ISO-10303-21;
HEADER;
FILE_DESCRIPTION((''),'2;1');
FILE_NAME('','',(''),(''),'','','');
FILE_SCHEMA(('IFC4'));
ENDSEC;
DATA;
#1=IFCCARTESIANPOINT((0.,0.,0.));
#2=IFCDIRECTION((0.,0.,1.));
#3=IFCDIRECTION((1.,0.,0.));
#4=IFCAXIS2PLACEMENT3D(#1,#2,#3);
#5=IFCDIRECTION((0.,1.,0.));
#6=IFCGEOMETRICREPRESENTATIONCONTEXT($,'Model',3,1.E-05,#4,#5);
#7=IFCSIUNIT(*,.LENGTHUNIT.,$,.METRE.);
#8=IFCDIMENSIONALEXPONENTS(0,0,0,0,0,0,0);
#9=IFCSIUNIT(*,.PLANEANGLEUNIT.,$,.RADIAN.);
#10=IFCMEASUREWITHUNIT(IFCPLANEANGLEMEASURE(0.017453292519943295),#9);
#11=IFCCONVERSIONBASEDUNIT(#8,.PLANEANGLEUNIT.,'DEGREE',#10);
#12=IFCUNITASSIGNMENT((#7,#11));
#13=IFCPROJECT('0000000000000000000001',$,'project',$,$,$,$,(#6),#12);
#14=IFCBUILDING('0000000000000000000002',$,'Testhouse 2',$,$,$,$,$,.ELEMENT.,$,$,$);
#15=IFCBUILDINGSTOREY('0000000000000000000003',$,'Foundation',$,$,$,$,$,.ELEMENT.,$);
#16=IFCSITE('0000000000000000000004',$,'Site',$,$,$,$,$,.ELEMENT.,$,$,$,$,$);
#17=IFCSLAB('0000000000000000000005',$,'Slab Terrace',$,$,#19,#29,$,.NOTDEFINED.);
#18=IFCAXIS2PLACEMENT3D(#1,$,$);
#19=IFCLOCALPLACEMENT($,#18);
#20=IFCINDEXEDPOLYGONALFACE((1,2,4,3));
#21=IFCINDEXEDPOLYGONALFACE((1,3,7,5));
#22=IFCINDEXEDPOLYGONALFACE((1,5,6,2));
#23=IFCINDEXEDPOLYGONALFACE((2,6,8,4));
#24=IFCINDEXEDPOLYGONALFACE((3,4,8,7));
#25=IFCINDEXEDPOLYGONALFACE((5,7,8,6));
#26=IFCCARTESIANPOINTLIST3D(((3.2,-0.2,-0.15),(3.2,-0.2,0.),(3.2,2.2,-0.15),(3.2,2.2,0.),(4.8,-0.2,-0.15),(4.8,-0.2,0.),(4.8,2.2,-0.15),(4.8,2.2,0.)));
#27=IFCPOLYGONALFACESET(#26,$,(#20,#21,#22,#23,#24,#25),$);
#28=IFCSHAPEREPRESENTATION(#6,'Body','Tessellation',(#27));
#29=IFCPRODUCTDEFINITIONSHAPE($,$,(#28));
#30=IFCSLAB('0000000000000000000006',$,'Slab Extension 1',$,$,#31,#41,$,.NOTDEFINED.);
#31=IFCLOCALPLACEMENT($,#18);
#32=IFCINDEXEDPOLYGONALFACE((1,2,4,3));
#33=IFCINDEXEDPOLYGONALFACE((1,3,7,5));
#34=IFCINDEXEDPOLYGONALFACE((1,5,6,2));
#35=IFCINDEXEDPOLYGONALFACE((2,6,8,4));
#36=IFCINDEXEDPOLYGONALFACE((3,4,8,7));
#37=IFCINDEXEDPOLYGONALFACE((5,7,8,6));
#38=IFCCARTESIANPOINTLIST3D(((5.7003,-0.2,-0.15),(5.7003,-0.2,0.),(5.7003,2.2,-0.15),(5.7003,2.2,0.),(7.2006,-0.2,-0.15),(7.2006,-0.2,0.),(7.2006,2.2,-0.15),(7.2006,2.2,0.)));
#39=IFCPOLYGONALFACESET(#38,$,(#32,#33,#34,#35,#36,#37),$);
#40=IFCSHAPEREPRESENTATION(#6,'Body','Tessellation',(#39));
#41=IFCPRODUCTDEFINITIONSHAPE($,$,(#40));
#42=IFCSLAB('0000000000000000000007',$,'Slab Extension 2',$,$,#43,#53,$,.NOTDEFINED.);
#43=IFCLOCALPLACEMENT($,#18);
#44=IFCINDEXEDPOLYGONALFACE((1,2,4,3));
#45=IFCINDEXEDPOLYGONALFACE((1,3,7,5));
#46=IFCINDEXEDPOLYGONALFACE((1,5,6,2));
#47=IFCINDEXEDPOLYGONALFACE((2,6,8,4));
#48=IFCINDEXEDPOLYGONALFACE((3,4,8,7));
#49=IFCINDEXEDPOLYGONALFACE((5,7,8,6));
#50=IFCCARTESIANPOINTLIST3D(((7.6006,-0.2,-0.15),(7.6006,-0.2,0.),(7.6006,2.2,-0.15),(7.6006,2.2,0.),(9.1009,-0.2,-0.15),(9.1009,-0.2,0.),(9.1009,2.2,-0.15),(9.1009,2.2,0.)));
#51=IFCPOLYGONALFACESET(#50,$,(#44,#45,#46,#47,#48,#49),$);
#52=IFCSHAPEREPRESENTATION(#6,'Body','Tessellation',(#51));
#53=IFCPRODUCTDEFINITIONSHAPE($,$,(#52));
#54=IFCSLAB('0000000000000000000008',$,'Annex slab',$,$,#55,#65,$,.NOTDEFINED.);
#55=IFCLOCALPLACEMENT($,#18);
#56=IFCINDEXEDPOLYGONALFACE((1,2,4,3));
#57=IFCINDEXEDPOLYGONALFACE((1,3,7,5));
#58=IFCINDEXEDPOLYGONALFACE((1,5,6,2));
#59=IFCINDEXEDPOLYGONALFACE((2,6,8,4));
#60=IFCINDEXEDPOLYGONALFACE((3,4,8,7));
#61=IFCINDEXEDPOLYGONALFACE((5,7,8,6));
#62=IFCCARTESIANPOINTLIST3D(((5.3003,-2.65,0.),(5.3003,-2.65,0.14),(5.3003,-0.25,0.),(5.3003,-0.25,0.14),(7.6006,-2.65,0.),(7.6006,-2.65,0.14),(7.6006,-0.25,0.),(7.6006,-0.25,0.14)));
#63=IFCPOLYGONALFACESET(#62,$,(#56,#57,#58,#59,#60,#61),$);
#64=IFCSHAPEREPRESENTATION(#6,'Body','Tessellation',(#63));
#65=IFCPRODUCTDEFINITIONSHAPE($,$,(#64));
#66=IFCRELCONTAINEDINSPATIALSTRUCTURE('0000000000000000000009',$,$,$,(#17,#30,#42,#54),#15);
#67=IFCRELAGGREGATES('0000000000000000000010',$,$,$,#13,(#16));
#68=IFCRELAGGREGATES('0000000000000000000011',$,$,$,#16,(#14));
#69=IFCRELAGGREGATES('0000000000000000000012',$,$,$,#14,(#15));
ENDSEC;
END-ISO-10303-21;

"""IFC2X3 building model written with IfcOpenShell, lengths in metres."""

from ifc_helpers import new_model, entity, si_unit, converted_unit, direction, frame, origin_with_axes, place, context, project, spatial, polyline, outline, extrude, element, save


model = new_model("IFC2X3")

# Units and contexts
model_context = context("Model", 3, precision=1e-05, world=origin_with_axes(), true_north=direction((0.0, 1.0, 0.0)))
ifc_project = project(units=[si_unit("LENGTHUNIT", "METRE"), converted_unit("PLANEANGLEUNIT", "DEGREE", entity("IfcPlaneAngleMeasure", 0.017453292519943295), si_unit("PLANEANGLEUNIT", "RADIAN"), dimensions=[0, 0, 0, 0, 0, 0, 0])], contexts=[model_context])

# Site, building, storey
site = spatial("IfcSite", under=ifc_project, Name="Site", CompositionType="ELEMENT")
building = spatial("IfcBuilding", under=site, Name="Testhouse 2", CompositionType="ELEMENT")
storey = spatial("IfcBuildingStorey", under=building, Name="Foundation", CompositionType="ELEMENT")

# Slabs
slab_1_placement = place(None, origin_with_axes())
element("IfcSlab", 1, at=slab_1_placement, inside=storey, Name="Slab Terrace", PredefinedType="NOTDEFINED", context=model_context, shape_type="SweptSolid", body=[
    extrude(outline(polyline([(0.0, 0.0), (-1.6, 0.0), (-1.6, 2.4), (0.0, 2.4), (0.0, 0.0)])), frame((4.8, -0.2, -0.15), z_axis=(0.0, 0.0, 1.0), x_axis=(1.0, 0.0, 0.0)), (0.0, 0.0, 1.0), 0.15),
])
slab_2_placement = place(None, origin_with_axes())
element("IfcSlab", 2, at=slab_2_placement, inside=storey, Name="Slab Extension 1", PredefinedType="NOTDEFINED", context=model_context, shape_type="SweptSolid", body=[
    extrude(outline(polyline([(0.0, 0.0), (1.5003, 0.0), (1.5003, -2.4), (0.0, -2.4), (0.0, 0.0)])), frame((5.7003, 2.2, -0.15), z_axis=(0.0, 0.0, 1.0), x_axis=(1.0, 0.0, 0.0)), (0.0, 0.0, 1.0), 0.15),
])
slab_3_placement = place(None, origin_with_axes())
element("IfcSlab", 3, at=slab_3_placement, inside=storey, Name="Slab Extension 2", PredefinedType="NOTDEFINED", context=model_context, shape_type="SweptSolid", body=[
    extrude(outline(polyline([(0.0, 0.0), (1.5003, 0.0), (1.5003, -2.4), (0.0, -2.4), (0.0, 0.0)])), frame((7.6006, 2.2, -0.15), z_axis=(0.0, 0.0, 1.0), x_axis=(1.0, 0.0, 0.0)), (0.0, 0.0, 1.0), 0.15),
])
slab_4_placement = place(None, origin_with_axes())
element("IfcSlab", 4, at=slab_4_placement, inside=storey, Name="Annex slab", PredefinedType="NOTDEFINED", context=model_context, shape_type="SweptSolid", body=[
    extrude(outline(polyline([(0.0, 0.0), (2.3003, 0.0), (2.3003, -2.4), (0.0, -2.4), (0.0, 0.0)])), frame((5.3003, -0.25, 0.0), z_axis=(0.0, 0.0, 1.0), x_axis=(1.0, 0.0, 0.0)), (0.0, 0.0, 1.0), 0.14),
])

save(model, "model.ifc")
